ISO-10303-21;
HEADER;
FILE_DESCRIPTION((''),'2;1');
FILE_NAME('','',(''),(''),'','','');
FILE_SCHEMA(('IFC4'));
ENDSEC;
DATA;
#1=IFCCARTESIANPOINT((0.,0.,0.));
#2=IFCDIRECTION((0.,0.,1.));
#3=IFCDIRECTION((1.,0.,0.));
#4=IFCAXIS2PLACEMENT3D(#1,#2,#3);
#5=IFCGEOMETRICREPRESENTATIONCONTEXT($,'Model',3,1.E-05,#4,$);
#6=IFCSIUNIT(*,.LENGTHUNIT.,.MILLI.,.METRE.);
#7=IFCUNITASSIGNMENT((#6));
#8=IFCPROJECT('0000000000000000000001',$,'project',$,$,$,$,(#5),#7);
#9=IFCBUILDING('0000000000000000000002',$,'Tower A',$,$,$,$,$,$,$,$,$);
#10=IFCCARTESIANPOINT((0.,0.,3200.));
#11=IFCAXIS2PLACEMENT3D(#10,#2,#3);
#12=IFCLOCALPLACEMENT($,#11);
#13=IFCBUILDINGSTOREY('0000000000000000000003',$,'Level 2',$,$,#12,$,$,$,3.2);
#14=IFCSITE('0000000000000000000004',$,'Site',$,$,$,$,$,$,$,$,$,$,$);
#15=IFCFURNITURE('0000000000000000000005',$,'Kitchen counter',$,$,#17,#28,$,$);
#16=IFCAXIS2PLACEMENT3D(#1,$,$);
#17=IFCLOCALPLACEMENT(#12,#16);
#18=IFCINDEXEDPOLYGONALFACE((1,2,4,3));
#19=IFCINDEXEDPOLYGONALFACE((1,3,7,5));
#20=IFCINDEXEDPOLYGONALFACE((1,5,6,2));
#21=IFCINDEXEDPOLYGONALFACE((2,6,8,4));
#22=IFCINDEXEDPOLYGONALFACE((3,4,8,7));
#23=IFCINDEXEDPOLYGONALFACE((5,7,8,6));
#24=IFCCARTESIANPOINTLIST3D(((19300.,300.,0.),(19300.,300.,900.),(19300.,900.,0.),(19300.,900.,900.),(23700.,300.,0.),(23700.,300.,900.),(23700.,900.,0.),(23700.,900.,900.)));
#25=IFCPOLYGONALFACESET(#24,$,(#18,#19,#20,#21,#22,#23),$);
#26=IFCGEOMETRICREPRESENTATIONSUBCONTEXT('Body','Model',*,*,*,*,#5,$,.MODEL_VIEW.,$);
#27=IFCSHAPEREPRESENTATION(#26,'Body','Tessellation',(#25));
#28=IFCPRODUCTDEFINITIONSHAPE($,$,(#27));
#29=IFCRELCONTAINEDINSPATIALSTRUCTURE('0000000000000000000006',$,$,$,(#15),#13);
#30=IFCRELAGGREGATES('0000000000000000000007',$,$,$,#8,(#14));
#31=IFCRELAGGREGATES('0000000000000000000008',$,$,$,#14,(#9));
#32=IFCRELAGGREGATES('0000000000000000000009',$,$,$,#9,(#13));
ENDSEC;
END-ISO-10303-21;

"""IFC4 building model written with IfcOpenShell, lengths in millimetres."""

from ifc_helpers import new_model, si_unit, frame, origin_with_axes, place, context, subcontext, project, spatial, indexed_curve, outline, extrude, element, save


model = new_model("IFC4")

# Units and contexts
model_context = context("Model", 3, precision=1e-05, world=origin_with_axes())
body_context = subcontext(model_context, "Body", "Model", "MODEL_VIEW")
ifc_project = project(units=[si_unit("LENGTHUNIT", "METRE", prefix="MILLI")], contexts=[model_context])

# Site, building, storey
site = spatial("IfcSite", under=ifc_project, Name="Site")
building = spatial("IfcBuilding", under=site, Name="Tower A")
storey_placement = place(None, frame((0.0, 0.0, 3200.0), z_axis=(0.0, 0.0, 1.0), x_axis=(1.0, 0.0, 0.0)))
storey = spatial("IfcBuildingStorey", under=building, at=storey_placement, Name="Level 2", Elevation=3.2)

# Furniture
furniture_1_placement = place(storey_placement, frame((19300.0, 300.0, 0.0), z_axis=(0.0, 0.0, 1.0), x_axis=(1.0, 0.0, 0.0)))
element("IfcFurniture", 1, at=furniture_1_placement, inside=storey, Name="Kitchen counter", context=body_context, shape_type="SweptSolid", body=[
    extrude(outline(indexed_curve([(0.0, 0.0), (4400.0, 0.0), (4400.0, 600.0), (0.0, 600.0)])), None, (0.0, 0.0, 1.0), 900.0),
])

save(model, "model.ifc")
